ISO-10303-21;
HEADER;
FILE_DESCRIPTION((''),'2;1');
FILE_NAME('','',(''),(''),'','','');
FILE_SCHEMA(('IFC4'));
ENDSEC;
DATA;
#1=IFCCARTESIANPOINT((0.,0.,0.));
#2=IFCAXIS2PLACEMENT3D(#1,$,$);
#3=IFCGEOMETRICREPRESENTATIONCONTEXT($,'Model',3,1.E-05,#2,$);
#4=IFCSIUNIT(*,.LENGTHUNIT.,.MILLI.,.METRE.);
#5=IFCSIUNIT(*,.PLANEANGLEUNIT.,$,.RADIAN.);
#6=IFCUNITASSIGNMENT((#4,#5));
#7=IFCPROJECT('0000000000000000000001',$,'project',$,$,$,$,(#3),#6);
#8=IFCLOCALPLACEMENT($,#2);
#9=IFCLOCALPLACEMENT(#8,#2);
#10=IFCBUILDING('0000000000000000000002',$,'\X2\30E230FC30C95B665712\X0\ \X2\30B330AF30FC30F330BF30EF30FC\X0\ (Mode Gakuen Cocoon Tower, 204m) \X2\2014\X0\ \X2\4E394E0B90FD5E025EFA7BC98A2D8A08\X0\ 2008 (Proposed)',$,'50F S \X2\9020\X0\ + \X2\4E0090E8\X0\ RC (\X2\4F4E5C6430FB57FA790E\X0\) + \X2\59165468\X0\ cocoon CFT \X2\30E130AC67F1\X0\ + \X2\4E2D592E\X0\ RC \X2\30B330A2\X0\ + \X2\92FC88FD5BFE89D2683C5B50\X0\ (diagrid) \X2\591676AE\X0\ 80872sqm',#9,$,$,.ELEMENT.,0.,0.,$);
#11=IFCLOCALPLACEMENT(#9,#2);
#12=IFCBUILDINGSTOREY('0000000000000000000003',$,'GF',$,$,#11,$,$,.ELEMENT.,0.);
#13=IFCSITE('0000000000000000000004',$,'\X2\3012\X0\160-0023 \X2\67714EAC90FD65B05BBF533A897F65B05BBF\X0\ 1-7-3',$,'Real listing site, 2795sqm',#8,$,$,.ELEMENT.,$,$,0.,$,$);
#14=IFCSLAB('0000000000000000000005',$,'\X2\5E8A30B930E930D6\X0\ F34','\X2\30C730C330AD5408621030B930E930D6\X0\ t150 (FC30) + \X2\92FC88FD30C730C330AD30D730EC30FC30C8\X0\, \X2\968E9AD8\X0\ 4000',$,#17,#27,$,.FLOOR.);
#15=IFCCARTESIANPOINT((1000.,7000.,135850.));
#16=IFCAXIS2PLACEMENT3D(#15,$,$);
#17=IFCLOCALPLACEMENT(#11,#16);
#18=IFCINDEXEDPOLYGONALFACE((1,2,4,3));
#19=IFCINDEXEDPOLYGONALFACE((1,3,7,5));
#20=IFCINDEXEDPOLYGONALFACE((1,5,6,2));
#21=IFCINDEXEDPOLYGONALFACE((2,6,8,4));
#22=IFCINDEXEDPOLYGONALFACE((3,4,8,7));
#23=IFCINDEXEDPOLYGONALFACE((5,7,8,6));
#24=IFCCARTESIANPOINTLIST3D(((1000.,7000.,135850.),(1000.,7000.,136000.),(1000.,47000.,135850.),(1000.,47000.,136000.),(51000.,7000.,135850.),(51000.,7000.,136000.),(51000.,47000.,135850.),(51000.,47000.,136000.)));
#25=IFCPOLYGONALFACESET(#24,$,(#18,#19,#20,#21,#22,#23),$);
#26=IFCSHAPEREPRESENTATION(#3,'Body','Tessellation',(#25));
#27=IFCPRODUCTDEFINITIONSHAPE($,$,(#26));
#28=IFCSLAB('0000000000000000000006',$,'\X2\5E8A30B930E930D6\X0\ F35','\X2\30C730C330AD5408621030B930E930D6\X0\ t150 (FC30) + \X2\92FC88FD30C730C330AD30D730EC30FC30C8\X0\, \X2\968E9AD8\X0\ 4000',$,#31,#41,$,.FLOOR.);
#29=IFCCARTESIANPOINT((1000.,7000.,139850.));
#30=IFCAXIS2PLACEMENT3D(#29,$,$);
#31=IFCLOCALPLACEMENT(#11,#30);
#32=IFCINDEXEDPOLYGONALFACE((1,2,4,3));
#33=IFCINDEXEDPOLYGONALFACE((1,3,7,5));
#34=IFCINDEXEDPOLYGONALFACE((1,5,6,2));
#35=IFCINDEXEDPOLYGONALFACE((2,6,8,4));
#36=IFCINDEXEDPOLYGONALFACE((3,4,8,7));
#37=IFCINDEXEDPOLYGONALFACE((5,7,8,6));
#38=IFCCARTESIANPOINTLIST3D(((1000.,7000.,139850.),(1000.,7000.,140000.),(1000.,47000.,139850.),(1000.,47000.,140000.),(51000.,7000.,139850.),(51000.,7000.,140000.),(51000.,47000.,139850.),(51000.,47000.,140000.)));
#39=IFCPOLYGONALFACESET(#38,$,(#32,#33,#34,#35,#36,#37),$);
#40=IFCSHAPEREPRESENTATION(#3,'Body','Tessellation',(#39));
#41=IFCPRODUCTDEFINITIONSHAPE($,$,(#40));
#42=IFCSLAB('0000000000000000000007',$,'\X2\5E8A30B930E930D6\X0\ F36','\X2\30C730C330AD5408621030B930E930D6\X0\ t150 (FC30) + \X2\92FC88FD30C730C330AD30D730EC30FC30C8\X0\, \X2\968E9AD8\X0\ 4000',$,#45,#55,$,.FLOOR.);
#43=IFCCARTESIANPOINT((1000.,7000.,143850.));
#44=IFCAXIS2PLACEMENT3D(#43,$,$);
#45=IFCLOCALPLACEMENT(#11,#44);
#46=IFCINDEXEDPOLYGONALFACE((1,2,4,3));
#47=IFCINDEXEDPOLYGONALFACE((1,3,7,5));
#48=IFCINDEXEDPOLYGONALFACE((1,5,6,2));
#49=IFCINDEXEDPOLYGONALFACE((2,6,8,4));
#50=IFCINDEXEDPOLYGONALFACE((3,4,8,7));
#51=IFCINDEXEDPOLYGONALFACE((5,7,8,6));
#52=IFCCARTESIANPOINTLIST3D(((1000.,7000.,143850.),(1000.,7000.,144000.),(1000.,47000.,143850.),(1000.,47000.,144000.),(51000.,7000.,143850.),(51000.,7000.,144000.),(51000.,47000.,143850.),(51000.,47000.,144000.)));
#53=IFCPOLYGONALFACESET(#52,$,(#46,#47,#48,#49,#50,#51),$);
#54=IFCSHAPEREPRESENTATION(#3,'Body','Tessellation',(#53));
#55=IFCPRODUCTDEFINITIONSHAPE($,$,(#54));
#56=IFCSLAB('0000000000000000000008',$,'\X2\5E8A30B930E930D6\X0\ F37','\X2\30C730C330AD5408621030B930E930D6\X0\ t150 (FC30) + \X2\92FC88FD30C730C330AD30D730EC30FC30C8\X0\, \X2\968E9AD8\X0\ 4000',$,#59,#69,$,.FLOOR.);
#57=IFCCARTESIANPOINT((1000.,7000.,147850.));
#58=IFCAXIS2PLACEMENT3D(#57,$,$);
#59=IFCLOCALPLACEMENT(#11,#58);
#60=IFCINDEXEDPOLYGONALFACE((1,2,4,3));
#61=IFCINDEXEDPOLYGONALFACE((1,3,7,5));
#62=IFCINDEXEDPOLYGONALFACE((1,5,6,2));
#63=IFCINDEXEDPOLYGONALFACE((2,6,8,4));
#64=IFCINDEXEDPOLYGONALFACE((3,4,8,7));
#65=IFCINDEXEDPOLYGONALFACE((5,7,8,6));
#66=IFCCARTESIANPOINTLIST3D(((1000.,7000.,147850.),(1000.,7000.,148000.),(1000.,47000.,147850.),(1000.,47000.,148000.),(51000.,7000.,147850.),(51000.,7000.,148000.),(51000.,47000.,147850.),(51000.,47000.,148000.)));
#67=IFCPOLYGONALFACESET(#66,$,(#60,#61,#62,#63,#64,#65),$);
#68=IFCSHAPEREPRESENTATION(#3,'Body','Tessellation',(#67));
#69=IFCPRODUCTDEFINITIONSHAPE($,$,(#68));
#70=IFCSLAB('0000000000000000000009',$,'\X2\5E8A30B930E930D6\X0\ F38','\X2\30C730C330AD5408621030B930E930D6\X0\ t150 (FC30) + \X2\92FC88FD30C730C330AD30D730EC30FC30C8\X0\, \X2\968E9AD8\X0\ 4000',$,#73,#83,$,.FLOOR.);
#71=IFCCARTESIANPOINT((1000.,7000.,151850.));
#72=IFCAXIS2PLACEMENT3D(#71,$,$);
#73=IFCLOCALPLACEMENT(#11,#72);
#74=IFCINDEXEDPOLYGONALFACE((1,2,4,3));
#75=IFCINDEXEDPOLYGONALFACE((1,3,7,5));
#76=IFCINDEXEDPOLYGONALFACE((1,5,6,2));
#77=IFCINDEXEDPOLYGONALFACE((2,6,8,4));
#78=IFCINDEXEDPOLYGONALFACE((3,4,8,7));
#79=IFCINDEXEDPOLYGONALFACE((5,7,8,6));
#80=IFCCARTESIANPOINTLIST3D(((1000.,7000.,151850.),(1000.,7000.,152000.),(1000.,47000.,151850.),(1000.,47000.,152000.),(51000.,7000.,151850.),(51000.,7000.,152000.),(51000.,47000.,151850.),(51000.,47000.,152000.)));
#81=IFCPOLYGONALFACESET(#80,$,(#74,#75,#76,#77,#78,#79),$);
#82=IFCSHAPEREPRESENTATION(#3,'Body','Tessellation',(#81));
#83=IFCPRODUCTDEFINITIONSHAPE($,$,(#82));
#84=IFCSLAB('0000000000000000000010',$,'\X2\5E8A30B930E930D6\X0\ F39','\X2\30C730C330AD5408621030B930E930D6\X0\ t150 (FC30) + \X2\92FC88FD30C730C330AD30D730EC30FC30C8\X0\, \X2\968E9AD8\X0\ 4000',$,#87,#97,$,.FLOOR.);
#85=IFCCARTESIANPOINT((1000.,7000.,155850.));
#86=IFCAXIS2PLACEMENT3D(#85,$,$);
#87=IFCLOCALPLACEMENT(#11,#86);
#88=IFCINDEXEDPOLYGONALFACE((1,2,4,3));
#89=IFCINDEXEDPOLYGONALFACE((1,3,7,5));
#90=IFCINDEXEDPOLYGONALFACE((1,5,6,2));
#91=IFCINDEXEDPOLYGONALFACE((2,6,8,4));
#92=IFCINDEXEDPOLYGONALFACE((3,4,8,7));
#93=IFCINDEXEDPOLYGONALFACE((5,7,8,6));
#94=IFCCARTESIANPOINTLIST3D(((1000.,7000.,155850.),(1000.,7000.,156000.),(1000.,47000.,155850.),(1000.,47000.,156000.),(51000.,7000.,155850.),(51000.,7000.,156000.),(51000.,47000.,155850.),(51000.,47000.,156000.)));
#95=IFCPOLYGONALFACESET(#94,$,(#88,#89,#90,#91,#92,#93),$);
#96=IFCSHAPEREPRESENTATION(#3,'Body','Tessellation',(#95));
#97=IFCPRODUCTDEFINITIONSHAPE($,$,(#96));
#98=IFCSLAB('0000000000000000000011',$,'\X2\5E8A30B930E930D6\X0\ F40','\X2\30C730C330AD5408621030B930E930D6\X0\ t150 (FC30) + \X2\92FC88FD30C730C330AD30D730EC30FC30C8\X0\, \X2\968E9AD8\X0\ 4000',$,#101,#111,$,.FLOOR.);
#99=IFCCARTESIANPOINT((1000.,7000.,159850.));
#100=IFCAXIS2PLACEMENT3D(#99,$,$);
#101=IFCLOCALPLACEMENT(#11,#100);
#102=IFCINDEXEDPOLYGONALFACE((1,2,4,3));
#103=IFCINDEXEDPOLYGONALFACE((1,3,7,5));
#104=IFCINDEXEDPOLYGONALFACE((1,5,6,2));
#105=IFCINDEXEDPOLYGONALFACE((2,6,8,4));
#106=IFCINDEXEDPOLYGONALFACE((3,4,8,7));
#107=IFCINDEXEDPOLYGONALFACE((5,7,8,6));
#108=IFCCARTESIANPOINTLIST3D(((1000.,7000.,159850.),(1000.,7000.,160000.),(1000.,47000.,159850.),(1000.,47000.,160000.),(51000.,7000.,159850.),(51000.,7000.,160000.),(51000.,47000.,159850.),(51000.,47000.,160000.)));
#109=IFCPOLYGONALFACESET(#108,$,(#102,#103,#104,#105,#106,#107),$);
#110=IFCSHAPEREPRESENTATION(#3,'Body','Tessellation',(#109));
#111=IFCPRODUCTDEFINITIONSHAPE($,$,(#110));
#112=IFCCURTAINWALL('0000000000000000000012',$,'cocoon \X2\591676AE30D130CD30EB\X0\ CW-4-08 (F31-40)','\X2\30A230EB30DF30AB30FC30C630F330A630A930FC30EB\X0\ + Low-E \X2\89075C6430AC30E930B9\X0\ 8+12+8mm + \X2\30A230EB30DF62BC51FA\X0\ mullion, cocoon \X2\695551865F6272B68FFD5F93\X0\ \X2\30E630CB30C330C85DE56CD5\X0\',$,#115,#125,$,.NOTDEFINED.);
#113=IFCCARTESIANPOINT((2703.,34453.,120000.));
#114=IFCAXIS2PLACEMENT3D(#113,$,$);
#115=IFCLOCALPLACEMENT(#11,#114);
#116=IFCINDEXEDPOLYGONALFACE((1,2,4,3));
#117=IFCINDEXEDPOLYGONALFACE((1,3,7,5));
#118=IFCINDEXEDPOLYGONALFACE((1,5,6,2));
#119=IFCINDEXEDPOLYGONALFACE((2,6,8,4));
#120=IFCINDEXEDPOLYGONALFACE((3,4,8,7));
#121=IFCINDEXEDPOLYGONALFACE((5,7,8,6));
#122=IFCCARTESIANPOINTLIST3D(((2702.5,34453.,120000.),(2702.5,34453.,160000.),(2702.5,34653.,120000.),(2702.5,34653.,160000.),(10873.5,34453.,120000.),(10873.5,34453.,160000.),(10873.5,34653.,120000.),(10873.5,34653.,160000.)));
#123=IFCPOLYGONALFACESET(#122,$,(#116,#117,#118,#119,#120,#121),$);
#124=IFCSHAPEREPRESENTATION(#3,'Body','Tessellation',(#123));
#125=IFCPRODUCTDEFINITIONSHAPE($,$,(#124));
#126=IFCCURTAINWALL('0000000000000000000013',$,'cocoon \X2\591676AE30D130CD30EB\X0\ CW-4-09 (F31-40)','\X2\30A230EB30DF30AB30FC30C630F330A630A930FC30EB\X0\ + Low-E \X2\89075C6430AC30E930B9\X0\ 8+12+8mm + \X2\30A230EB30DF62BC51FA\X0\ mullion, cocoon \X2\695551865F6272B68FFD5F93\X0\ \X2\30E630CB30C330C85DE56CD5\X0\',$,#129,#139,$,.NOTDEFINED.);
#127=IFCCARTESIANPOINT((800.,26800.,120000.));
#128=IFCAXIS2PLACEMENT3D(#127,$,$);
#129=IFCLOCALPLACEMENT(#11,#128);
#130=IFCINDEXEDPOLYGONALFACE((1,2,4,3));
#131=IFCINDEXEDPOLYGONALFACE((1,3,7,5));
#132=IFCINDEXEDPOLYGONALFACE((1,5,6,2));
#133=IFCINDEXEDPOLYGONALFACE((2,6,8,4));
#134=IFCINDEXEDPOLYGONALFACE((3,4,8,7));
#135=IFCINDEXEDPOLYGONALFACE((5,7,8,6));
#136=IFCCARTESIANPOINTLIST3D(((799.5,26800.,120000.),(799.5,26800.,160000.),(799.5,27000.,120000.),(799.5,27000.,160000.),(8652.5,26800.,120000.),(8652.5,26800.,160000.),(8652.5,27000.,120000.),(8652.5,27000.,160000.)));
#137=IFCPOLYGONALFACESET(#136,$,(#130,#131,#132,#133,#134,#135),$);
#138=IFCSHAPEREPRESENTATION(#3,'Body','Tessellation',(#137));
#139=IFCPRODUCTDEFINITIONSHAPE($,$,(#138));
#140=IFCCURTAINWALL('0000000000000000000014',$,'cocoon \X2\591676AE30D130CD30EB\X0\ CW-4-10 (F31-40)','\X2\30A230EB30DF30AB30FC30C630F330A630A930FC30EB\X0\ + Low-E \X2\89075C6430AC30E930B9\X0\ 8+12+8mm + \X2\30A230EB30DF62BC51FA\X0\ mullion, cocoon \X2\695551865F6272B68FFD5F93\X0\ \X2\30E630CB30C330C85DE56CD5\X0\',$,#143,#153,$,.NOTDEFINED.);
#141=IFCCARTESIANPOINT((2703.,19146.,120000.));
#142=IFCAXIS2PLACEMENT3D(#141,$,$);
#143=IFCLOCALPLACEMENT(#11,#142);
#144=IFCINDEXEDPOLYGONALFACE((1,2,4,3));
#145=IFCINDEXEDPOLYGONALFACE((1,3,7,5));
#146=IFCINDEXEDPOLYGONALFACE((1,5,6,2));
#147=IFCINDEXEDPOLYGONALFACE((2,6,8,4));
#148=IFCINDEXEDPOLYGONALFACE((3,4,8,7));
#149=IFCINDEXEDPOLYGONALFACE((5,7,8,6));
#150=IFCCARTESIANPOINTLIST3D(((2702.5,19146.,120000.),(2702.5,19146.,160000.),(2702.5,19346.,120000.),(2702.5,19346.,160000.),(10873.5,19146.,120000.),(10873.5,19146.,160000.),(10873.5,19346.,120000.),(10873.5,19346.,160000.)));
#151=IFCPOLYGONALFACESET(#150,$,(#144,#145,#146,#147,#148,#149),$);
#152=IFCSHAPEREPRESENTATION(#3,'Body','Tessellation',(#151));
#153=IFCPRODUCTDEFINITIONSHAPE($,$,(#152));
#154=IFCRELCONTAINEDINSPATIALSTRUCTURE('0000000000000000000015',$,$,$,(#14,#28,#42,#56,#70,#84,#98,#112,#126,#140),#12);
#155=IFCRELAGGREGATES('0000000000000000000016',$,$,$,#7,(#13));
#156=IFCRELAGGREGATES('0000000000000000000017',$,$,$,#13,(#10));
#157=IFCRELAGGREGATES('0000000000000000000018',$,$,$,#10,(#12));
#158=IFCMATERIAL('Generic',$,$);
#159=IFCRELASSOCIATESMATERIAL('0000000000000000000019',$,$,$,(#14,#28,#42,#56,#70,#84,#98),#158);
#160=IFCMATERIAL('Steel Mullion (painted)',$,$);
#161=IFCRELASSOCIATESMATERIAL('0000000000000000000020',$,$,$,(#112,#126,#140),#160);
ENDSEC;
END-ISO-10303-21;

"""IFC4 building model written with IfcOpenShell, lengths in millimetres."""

from ifc_helpers import new_model, si_unit, frame, frame_2d, origin, place, context, project, spatial, rectangle, extrude, material, element, save


model = new_model("IFC4")

# Units and contexts
model_context = context("Model", 3, precision=1e-05, world=origin())
ifc_project = project(units=[si_unit("LENGTHUNIT", "METRE", prefix="MILLI"), si_unit("PLANEANGLEUNIT", "RADIAN")], contexts=[model_context])

# Site, building, storey
site_placement = place(None, origin())
site = spatial("IfcSite", under=ifc_project, at=site_placement, Name="〒160-0023 東京都新宿区西新宿 1-7-3", ObjectType="Real listing site, 2795sqm", CompositionType="ELEMENT", RefElevation=0.0)
building_placement = place(site_placement, origin())
building = spatial("IfcBuilding", under=site, at=building_placement, Name="モード学園 コクーンタワー (Mode Gakuen Cocoon Tower, 204m) — 丹下都市建築設計 2008 (Proposed)", ObjectType="50F S 造 + 一部 RC (低層・基礎) + 外周 cocoon CFT メガ柱 + 中央 RC コア + 鋼製対角格子 (diagrid) 外皮 80872sqm", CompositionType="ELEMENT", ElevationOfRefHeight=0.0, ElevationOfTerrain=0.0)
storey_placement = place(building_placement, origin())
storey = spatial("IfcBuildingStorey", under=building, at=storey_placement, Name="GF", CompositionType="ELEMENT", Elevation=0.0)

# Shared definitions
ifc_material_1 = material(Name="Generic")

# Slabs
slab_1_placement = place(storey_placement, frame((1000.0, 7000.0, 135850.0)))
element("IfcSlab", 1, at=slab_1_placement, inside=storey, material=ifc_material_1, Name="床スラブ F34", Description="デッキ合成スラブ t150 (FC30) + 鋼製デッキプレート, 階高 4000", PredefinedType="FLOOR", context=model_context, shape_type="SweptSolid", body=[
    extrude(rectangle(XDim=50000.0, YDim=40000.0, at=frame_2d((25000.0, 20000.0))), frame((1000.0, 7000.0, 135850.0)), (0.0, 0.0, 1.0), 150.0),
])
slab_2_placement = place(storey_placement, frame((1000.0, 7000.0, 139850.0)))
element("IfcSlab", 2, at=slab_2_placement, inside=storey, material=ifc_material_1, Name="床スラブ F35", Description="デッキ合成スラブ t150 (FC30) + 鋼製デッキプレート, 階高 4000", PredefinedType="FLOOR", context=model_context, shape_type="SweptSolid", body=[
    extrude(rectangle(XDim=50000.0, YDim=40000.0, at=frame_2d((25000.0, 20000.0))), frame((1000.0, 7000.0, 139850.0)), (0.0, 0.0, 1.0), 150.0),
])
slab_3_placement = place(storey_placement, frame((1000.0, 7000.0, 143850.0)))
element("IfcSlab", 3, at=slab_3_placement, inside=storey, material=ifc_material_1, Name="床スラブ F36", Description="デッキ合成スラブ t150 (FC30) + 鋼製デッキプレート, 階高 4000", PredefinedType="FLOOR", context=model_context, shape_type="SweptSolid", body=[
    extrude(rectangle(XDim=50000.0, YDim=40000.0, at=frame_2d((25000.0, 20000.0))), frame((1000.0, 7000.0, 143850.0)), (0.0, 0.0, 1.0), 150.0),
])
slab_4_placement = place(storey_placement, frame((1000.0, 7000.0, 147850.0)))
element("IfcSlab", 4, at=slab_4_placement, inside=storey, material=ifc_material_1, Name="床スラブ F37", Description="デッキ合成スラブ t150 (FC30) + 鋼製デッキプレート, 階高 4000", PredefinedType="FLOOR", context=model_context, shape_type="SweptSolid", body=[
    extrude(rectangle(XDim=50000.0, YDim=40000.0, at=frame_2d((25000.0, 20000.0))), frame((1000.0, 7000.0, 147850.0)), (0.0, 0.0, 1.0), 150.0),
])
slab_5_placement = place(storey_placement, frame((1000.0, 7000.0, 151850.0)))
element("IfcSlab", 5, at=slab_5_placement, inside=storey, material=ifc_material_1, Name="床スラブ F38", Description="デッキ合成スラブ t150 (FC30) + 鋼製デッキプレート, 階高 4000", PredefinedType="FLOOR", context=model_context, shape_type="SweptSolid", body=[
    extrude(rectangle(XDim=50000.0, YDim=40000.0, at=frame_2d((25000.0, 20000.0))), frame((1000.0, 7000.0, 151850.0)), (0.0, 0.0, 1.0), 150.0),
])
slab_6_placement = place(storey_placement, frame((1000.0, 7000.0, 155850.0)))
element("IfcSlab", 6, at=slab_6_placement, inside=storey, material=ifc_material_1, Name="床スラブ F39", Description="デッキ合成スラブ t150 (FC30) + 鋼製デッキプレート, 階高 4000", PredefinedType="FLOOR", context=model_context, shape_type="SweptSolid", body=[
    extrude(rectangle(XDim=50000.0, YDim=40000.0, at=frame_2d((25000.0, 20000.0))), frame((1000.0, 7000.0, 155850.0)), (0.0, 0.0, 1.0), 150.0),
])
slab_7_placement = place(storey_placement, frame((1000.0, 7000.0, 159850.0)))
element("IfcSlab", 7, at=slab_7_placement, inside=storey, material=ifc_material_1, Name="床スラブ F40", Description="デッキ合成スラブ t150 (FC30) + 鋼製デッキプレート, 階高 4000", PredefinedType="FLOOR", context=model_context, shape_type="SweptSolid", body=[
    extrude(rectangle(XDim=50000.0, YDim=40000.0, at=frame_2d((25000.0, 20000.0))), frame((1000.0, 7000.0, 159850.0)), (0.0, 0.0, 1.0), 150.0),
])

# Curtain walls
ifc_material_2 = material(Name="Steel Mullion (painted)")
curtain_wall_1_placement = place(storey_placement, frame((2703.0, 34453.0, 120000.0)))
element("IfcCurtainWall", 8, at=curtain_wall_1_placement, inside=storey, material=ifc_material_2, Name="cocoon 外皮パネル CW-4-08 (F31-40)", Description="アルミカーテンウォール + Low-E 複層ガラス 8+12+8mm + アルミ押出 mullion, cocoon 楕円形状追従 ユニット工法", PredefinedType="NOTDEFINED", context=model_context, shape_type="SweptSolid", body=[
    extrude(rectangle(XDim=8171.0, YDim=200.0, at=frame_2d((4085.0, 100.0))), frame((2703.0, 34453.0, 120000.0)), (0.0, 0.0, 1.0), 40000.0),
])
curtain_wall_2_placement = place(storey_placement, frame((800.0, 26800.0, 120000.0)))
element("IfcCurtainWall", 9, at=curtain_wall_2_placement, inside=storey, material=ifc_material_2, Name="cocoon 外皮パネル CW-4-09 (F31-40)", Description="アルミカーテンウォール + Low-E 複層ガラス 8+12+8mm + アルミ押出 mullion, cocoon 楕円形状追従 ユニット工法", PredefinedType="NOTDEFINED", context=model_context, shape_type="SweptSolid", body=[
    extrude(rectangle(XDim=7853.0, YDim=200.0, at=frame_2d((3926.0, 100.0))), frame((800.0, 26800.0, 120000.0)), (0.0, 0.0, 1.0), 40000.0),
])
curtain_wall_3_placement = place(storey_placement, frame((2703.0, 19146.0, 120000.0)))
element("IfcCurtainWall", 10, at=curtain_wall_3_placement, inside=storey, material=ifc_material_2, Name="cocoon 外皮パネル CW-4-10 (F31-40)", Description="アルミカーテンウォール + Low-E 複層ガラス 8+12+8mm + アルミ押出 mullion, cocoon 楕円形状追従 ユニット工法", PredefinedType="NOTDEFINED", context=model_context, shape_type="SweptSolid", body=[
    extrude(rectangle(XDim=8171.0, YDim=200.0, at=frame_2d((4085.0, 100.0))), frame((2703.0, 19146.0, 120000.0)), (0.0, 0.0, 1.0), 40000.0),
])

save(model, "model.ifc")
